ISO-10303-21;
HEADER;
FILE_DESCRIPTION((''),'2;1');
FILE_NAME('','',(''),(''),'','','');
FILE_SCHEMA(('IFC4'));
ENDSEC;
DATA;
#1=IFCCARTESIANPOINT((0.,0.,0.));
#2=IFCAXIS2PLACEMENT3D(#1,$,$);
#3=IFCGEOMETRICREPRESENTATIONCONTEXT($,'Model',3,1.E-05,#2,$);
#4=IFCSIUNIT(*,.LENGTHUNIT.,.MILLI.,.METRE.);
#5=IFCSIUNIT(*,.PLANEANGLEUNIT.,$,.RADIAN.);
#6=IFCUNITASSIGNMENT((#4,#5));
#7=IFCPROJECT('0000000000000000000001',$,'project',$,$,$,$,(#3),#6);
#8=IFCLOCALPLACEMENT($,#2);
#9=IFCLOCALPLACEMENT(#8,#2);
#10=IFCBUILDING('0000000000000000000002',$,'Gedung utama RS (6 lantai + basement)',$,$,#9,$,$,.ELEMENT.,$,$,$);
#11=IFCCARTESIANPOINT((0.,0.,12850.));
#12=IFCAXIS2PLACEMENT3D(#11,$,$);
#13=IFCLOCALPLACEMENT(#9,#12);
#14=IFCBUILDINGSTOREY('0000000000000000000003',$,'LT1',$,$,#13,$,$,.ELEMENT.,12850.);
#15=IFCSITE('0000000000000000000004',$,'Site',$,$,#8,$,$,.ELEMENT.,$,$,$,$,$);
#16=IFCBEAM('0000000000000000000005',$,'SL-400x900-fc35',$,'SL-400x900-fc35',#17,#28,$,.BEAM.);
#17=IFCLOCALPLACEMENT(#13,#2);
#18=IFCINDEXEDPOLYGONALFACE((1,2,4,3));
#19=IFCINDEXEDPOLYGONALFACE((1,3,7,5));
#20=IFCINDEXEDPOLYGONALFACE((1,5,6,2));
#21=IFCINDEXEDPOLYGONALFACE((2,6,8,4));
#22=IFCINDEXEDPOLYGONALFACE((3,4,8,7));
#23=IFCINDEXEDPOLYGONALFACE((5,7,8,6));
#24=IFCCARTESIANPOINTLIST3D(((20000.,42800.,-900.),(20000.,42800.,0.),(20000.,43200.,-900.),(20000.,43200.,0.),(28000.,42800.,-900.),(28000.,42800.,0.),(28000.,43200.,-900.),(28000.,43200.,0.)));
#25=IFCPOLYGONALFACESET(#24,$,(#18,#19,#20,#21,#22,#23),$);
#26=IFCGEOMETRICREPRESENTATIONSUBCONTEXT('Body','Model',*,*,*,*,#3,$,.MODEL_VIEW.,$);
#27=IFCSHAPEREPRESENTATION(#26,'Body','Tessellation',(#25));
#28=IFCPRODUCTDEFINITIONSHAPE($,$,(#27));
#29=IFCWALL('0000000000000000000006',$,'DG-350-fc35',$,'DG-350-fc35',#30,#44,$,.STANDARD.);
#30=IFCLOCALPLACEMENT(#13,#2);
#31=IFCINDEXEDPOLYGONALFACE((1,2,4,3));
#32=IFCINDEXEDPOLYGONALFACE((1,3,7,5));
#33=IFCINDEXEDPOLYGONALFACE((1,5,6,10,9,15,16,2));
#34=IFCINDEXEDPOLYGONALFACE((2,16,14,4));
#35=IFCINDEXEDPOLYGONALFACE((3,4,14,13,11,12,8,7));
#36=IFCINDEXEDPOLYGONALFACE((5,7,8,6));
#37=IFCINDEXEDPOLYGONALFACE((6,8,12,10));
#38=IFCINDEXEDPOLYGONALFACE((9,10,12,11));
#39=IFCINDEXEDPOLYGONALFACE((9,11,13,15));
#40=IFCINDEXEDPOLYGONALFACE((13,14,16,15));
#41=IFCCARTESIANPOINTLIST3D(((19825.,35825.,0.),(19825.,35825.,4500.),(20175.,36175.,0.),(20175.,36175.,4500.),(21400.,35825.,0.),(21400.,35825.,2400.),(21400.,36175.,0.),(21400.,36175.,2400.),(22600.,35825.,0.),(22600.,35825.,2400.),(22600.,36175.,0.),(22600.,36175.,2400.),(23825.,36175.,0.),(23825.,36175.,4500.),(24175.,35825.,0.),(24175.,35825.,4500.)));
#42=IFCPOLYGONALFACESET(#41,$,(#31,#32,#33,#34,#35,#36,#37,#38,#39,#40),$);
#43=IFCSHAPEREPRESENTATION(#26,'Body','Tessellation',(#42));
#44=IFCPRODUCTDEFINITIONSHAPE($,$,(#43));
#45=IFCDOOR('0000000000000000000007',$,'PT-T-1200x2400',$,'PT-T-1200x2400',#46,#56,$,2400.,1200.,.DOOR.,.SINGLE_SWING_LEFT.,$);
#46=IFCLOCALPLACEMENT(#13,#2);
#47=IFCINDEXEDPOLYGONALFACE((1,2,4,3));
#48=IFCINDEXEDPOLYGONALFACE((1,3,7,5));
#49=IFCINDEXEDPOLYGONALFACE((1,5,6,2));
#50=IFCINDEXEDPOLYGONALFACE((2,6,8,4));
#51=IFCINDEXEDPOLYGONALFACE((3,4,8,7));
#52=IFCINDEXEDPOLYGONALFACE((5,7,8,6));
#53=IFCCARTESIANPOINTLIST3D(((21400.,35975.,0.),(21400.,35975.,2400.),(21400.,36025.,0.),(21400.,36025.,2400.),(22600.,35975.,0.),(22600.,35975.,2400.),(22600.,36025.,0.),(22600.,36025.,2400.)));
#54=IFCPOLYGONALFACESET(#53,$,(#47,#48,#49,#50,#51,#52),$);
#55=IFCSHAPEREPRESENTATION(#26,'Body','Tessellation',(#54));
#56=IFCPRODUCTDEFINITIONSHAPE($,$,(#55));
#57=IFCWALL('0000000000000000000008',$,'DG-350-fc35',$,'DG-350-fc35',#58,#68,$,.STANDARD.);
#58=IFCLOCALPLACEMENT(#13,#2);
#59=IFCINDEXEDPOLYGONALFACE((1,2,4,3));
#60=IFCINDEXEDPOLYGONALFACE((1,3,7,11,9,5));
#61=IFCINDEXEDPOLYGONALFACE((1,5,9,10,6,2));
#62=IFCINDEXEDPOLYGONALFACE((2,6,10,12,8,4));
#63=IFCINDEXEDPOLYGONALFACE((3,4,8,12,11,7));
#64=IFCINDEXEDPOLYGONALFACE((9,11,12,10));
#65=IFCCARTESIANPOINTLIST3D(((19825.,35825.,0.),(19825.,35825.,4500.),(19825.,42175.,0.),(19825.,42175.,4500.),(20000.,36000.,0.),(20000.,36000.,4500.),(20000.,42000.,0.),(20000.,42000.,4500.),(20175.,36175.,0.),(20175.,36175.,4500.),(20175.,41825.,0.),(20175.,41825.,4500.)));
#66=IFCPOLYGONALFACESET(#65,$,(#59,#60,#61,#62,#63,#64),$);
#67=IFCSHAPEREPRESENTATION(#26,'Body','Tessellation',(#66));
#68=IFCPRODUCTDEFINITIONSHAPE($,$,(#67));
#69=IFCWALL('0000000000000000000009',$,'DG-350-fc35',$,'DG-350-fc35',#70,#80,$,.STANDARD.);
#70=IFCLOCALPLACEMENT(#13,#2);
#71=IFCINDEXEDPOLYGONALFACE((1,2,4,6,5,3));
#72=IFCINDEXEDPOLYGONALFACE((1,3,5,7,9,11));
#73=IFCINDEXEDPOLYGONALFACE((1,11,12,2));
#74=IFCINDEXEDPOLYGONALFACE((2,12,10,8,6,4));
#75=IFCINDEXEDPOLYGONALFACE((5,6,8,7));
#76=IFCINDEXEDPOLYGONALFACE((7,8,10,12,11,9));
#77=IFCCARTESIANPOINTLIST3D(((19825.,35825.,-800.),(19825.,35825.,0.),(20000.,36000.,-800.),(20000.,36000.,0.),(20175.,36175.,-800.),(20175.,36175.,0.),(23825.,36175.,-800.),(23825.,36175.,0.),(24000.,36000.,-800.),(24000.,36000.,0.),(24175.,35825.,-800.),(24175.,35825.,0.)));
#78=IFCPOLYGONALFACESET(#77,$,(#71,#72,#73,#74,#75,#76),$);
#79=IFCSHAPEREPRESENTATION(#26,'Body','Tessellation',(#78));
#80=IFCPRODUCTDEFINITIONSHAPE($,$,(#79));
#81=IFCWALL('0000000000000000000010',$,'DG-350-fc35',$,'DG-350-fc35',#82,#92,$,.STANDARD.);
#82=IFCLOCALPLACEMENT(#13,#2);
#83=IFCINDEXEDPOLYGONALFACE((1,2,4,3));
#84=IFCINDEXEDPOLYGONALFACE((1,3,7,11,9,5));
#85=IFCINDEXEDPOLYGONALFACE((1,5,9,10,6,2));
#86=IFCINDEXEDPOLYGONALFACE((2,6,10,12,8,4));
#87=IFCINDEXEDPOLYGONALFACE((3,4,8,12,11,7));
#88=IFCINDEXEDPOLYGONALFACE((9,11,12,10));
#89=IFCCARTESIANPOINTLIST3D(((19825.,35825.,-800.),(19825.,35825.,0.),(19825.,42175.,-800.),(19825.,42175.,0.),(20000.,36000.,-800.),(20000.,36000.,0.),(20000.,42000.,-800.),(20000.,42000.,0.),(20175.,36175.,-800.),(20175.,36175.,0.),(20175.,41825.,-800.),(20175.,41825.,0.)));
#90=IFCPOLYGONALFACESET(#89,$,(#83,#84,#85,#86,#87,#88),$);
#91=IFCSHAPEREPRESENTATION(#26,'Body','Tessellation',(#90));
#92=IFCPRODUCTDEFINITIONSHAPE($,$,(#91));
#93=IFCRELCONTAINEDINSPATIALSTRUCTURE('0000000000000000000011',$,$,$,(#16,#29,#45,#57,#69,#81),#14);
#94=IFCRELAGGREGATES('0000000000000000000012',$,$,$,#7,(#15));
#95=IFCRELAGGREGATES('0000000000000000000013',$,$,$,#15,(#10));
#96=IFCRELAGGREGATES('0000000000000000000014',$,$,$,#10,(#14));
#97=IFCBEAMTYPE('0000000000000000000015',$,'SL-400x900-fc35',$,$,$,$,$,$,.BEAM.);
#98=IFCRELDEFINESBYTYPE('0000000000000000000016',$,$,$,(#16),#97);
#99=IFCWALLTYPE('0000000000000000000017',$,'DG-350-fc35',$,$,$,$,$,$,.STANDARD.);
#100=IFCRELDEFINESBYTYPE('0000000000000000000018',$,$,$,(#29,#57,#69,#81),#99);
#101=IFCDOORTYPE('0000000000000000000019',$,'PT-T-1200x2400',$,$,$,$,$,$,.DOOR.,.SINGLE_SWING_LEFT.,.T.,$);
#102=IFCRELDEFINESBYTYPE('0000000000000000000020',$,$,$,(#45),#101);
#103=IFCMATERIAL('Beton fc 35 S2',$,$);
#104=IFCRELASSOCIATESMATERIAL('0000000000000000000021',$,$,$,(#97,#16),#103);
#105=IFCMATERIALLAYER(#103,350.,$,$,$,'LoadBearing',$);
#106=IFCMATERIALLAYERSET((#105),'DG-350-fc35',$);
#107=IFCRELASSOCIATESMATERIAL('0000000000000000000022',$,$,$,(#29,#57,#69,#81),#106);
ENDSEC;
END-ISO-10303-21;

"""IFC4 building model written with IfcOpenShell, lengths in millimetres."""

from ifc_helpers import new_model, si_unit, frame, frame_2d, origin, origin_2d, place, context, subcontext, project, spatial, polyline, rectangle, outline, extrude, material, layer, layer_set, layer_usage, material_profile, profile_set, profile_usage, type_object, element, fill, save


model = new_model("IFC4")

# Units and contexts
model_context = context("Model", 3, precision=1e-05, world=origin())
body_context = subcontext(model_context, "Body", "Model", "MODEL_VIEW")
ifc_project = project(units=[si_unit("LENGTHUNIT", "METRE", prefix="MILLI"), si_unit("PLANEANGLEUNIT", "RADIAN")], contexts=[model_context])

# Site, building, storey
site_placement = place(None, origin())
site = spatial("IfcSite", under=ifc_project, at=site_placement, Name="Site", CompositionType="ELEMENT")
building_placement = place(site_placement, origin())
building = spatial("IfcBuilding", under=site, at=building_placement, Name="Gedung utama RS (6 lantai + basement)", CompositionType="ELEMENT")
storey_placement = place(building_placement, frame((0.0, 0.0, 12850.0)))
storey = spatial("IfcBuildingStorey", under=building, at=storey_placement, Name="LT1", CompositionType="ELEMENT", Elevation=12850.0)

# Beam
ifc_material = material(Name="Beton fc 35 S2")
ifc_material_profile_1 = material_profile(ifc_material, rectangle(XDim=400.0, YDim=900.0, at=origin_2d()), Name="SL-400x900-fc35")
ifc_profile_set_1 = profile_set([ifc_material_profile_1], Name="SL-400x900-fc35")
ifc_profile_usage_1 = profile_usage(ifc_profile_set_1, cardinal=8)
beam_type_1 = type_object("IfcBeamType", Name="SL-400x900-fc35", PredefinedType="BEAM", material=ifc_profile_set_1)
beam_1_placement = place(storey_placement, frame((20000.0, 43000.0, -450.0)))
element("IfcBeam", 1, at=beam_1_placement, inside=storey, type_object=beam_type_1, material=ifc_profile_usage_1, Name="SL-400x900-fc35", ObjectType="SL-400x900-fc35", PredefinedType="BEAM", context=body_context, shape_type="SweptSolid", body=[
    extrude(rectangle(XDim=400.0, YDim=900.0, at=origin_2d()), frame((0.0, 0.0, 0.0), z_axis=(1.0, 0.0, 0.0), x_axis=(0.0, 1.0, 0.0)), (0.0, 0.0, 1.0), 8000.0),
])

# Wall, opening, door
ifc_layer = layer(ifc_material, 350.0, Category="LoadBearing")
ifc_layer_set = layer_set([ifc_layer], Name="DG-350-fc35")
ifc_layer_usage = layer_usage(ifc_layer_set, "AXIS2", "NEGATIVE", 175.0)
wall_type = type_object("IfcWallType", Name="DG-350-fc35", PredefinedType="STANDARD")
wall_1_placement = place(storey_placement, frame((20000.0, 36000.0, 0.0), z_axis=(0.0, 0.0, 1.0), x_axis=(1.0, 0.0, 0.0)))
wall_1 = element("IfcWall", 2, at=wall_1_placement, inside=storey, type_object=wall_type, material=ifc_layer_usage, Name="DG-350-fc35", ObjectType="DG-350-fc35", PredefinedType="STANDARD", context=body_context, shape_type="SweptSolid", body=[
    extrude(outline(polyline([(-175.0, -175.0), (0.0, 0.0), (175.0, 175.0), (3825.0, 175.0), (4000.0, 0.0), (4175.0, -175.0), (-175.0, -175.0)])), origin(), (0.0, 0.0, 1.0), 4500.0),
])
opening_placement = place(wall_1_placement, frame((1400.0, 0.0, 0.0), z_axis=(0.0, 0.0, 1.0), x_axis=(1.0, 0.0, 0.0)))
opening = element("IfcOpeningElement", 3, at=opening_placement, cuts=wall_1, PredefinedType="OPENING", context=body_context, shape_type="SweptSolid", body=[
    extrude(rectangle(XDim=1200.0, YDim=370.0, at=frame_2d((600.0, 0.0))), origin(), (0.0, 0.0, 1.0), 2400.0),
])
door_type = type_object("IfcDoorType", Name="PT-T-1200x2400", OperationType="SINGLE_SWING_LEFT", ParameterTakesPrecedence=True, PredefinedType="DOOR")
door_placement = place(opening_placement, origin())
door = element("IfcDoor", 4, at=door_placement, inside=storey, type_object=door_type, Name="PT-T-1200x2400", ObjectType="PT-T-1200x2400", OperationType="SINGLE_SWING_LEFT", OverallHeight=2400.0, OverallWidth=1200.0, PredefinedType="DOOR", context=body_context, shape_type="SweptSolid", body=[
    extrude(rectangle(XDim=1200.0, YDim=50.0, at=frame_2d((600.0, 0.0))), origin(), (0.0, 0.0, 1.0), 2400.0),
])
fill(opening, door)

# Walls
wall_2_placement = place(storey_placement, frame((20000.0, 42000.0, 0.0), z_axis=(0.0, 0.0, 1.0), x_axis=(0.0, -1.0, 0.0)))
element("IfcWall", 5, at=wall_2_placement, inside=storey, type_object=wall_type, material=ifc_layer_usage, Name="DG-350-fc35", ObjectType="DG-350-fc35", PredefinedType="STANDARD", context=body_context, shape_type="SweptSolid", body=[
    extrude(outline(polyline([(-175.0, -175.0), (0.0, 0.0), (175.0, 175.0), (5825.0, 175.0), (6000.0, 0.0), (6175.0, -175.0), (-175.0, -175.0)])), origin(), (0.0, 0.0, 1.0), 4500.0),
])
wall_3_placement = place(storey_placement, frame((20000.0, 36000.0, -800.0), z_axis=(0.0, 0.0, 1.0), x_axis=(1.0, 0.0, 0.0)))
element("IfcWall", 6, at=wall_3_placement, inside=storey, type_object=wall_type, material=ifc_layer_usage, Name="DG-350-fc35", ObjectType="DG-350-fc35", PredefinedType="STANDARD", context=body_context, shape_type="SweptSolid", body=[
    extrude(outline(polyline([(-175.0, -175.0), (0.0, 0.0), (175.0, 175.0), (3825.0, 175.0), (4000.0, 0.0), (4175.0, -175.0), (-175.0, -175.0)])), origin(), (0.0, 0.0, 1.0), 800.0),
])
wall_4_placement = place(storey_placement, frame((20000.0, 42000.0, -800.0), z_axis=(0.0, 0.0, 1.0), x_axis=(0.0, -1.0, 0.0)))
element("IfcWall", 7, at=wall_4_placement, inside=storey, type_object=wall_type, material=ifc_layer_usage, Name="DG-350-fc35", ObjectType="DG-350-fc35", PredefinedType="STANDARD", context=body_context, shape_type="SweptSolid", body=[
    extrude(outline(polyline([(-175.0, -175.0), (0.0, 0.0), (175.0, 175.0), (5825.0, 175.0), (6000.0, 0.0), (6175.0, -175.0), (-175.0, -175.0)])), origin(), (0.0, 0.0, 1.0), 800.0),
])

save(model, "model.ifc")
